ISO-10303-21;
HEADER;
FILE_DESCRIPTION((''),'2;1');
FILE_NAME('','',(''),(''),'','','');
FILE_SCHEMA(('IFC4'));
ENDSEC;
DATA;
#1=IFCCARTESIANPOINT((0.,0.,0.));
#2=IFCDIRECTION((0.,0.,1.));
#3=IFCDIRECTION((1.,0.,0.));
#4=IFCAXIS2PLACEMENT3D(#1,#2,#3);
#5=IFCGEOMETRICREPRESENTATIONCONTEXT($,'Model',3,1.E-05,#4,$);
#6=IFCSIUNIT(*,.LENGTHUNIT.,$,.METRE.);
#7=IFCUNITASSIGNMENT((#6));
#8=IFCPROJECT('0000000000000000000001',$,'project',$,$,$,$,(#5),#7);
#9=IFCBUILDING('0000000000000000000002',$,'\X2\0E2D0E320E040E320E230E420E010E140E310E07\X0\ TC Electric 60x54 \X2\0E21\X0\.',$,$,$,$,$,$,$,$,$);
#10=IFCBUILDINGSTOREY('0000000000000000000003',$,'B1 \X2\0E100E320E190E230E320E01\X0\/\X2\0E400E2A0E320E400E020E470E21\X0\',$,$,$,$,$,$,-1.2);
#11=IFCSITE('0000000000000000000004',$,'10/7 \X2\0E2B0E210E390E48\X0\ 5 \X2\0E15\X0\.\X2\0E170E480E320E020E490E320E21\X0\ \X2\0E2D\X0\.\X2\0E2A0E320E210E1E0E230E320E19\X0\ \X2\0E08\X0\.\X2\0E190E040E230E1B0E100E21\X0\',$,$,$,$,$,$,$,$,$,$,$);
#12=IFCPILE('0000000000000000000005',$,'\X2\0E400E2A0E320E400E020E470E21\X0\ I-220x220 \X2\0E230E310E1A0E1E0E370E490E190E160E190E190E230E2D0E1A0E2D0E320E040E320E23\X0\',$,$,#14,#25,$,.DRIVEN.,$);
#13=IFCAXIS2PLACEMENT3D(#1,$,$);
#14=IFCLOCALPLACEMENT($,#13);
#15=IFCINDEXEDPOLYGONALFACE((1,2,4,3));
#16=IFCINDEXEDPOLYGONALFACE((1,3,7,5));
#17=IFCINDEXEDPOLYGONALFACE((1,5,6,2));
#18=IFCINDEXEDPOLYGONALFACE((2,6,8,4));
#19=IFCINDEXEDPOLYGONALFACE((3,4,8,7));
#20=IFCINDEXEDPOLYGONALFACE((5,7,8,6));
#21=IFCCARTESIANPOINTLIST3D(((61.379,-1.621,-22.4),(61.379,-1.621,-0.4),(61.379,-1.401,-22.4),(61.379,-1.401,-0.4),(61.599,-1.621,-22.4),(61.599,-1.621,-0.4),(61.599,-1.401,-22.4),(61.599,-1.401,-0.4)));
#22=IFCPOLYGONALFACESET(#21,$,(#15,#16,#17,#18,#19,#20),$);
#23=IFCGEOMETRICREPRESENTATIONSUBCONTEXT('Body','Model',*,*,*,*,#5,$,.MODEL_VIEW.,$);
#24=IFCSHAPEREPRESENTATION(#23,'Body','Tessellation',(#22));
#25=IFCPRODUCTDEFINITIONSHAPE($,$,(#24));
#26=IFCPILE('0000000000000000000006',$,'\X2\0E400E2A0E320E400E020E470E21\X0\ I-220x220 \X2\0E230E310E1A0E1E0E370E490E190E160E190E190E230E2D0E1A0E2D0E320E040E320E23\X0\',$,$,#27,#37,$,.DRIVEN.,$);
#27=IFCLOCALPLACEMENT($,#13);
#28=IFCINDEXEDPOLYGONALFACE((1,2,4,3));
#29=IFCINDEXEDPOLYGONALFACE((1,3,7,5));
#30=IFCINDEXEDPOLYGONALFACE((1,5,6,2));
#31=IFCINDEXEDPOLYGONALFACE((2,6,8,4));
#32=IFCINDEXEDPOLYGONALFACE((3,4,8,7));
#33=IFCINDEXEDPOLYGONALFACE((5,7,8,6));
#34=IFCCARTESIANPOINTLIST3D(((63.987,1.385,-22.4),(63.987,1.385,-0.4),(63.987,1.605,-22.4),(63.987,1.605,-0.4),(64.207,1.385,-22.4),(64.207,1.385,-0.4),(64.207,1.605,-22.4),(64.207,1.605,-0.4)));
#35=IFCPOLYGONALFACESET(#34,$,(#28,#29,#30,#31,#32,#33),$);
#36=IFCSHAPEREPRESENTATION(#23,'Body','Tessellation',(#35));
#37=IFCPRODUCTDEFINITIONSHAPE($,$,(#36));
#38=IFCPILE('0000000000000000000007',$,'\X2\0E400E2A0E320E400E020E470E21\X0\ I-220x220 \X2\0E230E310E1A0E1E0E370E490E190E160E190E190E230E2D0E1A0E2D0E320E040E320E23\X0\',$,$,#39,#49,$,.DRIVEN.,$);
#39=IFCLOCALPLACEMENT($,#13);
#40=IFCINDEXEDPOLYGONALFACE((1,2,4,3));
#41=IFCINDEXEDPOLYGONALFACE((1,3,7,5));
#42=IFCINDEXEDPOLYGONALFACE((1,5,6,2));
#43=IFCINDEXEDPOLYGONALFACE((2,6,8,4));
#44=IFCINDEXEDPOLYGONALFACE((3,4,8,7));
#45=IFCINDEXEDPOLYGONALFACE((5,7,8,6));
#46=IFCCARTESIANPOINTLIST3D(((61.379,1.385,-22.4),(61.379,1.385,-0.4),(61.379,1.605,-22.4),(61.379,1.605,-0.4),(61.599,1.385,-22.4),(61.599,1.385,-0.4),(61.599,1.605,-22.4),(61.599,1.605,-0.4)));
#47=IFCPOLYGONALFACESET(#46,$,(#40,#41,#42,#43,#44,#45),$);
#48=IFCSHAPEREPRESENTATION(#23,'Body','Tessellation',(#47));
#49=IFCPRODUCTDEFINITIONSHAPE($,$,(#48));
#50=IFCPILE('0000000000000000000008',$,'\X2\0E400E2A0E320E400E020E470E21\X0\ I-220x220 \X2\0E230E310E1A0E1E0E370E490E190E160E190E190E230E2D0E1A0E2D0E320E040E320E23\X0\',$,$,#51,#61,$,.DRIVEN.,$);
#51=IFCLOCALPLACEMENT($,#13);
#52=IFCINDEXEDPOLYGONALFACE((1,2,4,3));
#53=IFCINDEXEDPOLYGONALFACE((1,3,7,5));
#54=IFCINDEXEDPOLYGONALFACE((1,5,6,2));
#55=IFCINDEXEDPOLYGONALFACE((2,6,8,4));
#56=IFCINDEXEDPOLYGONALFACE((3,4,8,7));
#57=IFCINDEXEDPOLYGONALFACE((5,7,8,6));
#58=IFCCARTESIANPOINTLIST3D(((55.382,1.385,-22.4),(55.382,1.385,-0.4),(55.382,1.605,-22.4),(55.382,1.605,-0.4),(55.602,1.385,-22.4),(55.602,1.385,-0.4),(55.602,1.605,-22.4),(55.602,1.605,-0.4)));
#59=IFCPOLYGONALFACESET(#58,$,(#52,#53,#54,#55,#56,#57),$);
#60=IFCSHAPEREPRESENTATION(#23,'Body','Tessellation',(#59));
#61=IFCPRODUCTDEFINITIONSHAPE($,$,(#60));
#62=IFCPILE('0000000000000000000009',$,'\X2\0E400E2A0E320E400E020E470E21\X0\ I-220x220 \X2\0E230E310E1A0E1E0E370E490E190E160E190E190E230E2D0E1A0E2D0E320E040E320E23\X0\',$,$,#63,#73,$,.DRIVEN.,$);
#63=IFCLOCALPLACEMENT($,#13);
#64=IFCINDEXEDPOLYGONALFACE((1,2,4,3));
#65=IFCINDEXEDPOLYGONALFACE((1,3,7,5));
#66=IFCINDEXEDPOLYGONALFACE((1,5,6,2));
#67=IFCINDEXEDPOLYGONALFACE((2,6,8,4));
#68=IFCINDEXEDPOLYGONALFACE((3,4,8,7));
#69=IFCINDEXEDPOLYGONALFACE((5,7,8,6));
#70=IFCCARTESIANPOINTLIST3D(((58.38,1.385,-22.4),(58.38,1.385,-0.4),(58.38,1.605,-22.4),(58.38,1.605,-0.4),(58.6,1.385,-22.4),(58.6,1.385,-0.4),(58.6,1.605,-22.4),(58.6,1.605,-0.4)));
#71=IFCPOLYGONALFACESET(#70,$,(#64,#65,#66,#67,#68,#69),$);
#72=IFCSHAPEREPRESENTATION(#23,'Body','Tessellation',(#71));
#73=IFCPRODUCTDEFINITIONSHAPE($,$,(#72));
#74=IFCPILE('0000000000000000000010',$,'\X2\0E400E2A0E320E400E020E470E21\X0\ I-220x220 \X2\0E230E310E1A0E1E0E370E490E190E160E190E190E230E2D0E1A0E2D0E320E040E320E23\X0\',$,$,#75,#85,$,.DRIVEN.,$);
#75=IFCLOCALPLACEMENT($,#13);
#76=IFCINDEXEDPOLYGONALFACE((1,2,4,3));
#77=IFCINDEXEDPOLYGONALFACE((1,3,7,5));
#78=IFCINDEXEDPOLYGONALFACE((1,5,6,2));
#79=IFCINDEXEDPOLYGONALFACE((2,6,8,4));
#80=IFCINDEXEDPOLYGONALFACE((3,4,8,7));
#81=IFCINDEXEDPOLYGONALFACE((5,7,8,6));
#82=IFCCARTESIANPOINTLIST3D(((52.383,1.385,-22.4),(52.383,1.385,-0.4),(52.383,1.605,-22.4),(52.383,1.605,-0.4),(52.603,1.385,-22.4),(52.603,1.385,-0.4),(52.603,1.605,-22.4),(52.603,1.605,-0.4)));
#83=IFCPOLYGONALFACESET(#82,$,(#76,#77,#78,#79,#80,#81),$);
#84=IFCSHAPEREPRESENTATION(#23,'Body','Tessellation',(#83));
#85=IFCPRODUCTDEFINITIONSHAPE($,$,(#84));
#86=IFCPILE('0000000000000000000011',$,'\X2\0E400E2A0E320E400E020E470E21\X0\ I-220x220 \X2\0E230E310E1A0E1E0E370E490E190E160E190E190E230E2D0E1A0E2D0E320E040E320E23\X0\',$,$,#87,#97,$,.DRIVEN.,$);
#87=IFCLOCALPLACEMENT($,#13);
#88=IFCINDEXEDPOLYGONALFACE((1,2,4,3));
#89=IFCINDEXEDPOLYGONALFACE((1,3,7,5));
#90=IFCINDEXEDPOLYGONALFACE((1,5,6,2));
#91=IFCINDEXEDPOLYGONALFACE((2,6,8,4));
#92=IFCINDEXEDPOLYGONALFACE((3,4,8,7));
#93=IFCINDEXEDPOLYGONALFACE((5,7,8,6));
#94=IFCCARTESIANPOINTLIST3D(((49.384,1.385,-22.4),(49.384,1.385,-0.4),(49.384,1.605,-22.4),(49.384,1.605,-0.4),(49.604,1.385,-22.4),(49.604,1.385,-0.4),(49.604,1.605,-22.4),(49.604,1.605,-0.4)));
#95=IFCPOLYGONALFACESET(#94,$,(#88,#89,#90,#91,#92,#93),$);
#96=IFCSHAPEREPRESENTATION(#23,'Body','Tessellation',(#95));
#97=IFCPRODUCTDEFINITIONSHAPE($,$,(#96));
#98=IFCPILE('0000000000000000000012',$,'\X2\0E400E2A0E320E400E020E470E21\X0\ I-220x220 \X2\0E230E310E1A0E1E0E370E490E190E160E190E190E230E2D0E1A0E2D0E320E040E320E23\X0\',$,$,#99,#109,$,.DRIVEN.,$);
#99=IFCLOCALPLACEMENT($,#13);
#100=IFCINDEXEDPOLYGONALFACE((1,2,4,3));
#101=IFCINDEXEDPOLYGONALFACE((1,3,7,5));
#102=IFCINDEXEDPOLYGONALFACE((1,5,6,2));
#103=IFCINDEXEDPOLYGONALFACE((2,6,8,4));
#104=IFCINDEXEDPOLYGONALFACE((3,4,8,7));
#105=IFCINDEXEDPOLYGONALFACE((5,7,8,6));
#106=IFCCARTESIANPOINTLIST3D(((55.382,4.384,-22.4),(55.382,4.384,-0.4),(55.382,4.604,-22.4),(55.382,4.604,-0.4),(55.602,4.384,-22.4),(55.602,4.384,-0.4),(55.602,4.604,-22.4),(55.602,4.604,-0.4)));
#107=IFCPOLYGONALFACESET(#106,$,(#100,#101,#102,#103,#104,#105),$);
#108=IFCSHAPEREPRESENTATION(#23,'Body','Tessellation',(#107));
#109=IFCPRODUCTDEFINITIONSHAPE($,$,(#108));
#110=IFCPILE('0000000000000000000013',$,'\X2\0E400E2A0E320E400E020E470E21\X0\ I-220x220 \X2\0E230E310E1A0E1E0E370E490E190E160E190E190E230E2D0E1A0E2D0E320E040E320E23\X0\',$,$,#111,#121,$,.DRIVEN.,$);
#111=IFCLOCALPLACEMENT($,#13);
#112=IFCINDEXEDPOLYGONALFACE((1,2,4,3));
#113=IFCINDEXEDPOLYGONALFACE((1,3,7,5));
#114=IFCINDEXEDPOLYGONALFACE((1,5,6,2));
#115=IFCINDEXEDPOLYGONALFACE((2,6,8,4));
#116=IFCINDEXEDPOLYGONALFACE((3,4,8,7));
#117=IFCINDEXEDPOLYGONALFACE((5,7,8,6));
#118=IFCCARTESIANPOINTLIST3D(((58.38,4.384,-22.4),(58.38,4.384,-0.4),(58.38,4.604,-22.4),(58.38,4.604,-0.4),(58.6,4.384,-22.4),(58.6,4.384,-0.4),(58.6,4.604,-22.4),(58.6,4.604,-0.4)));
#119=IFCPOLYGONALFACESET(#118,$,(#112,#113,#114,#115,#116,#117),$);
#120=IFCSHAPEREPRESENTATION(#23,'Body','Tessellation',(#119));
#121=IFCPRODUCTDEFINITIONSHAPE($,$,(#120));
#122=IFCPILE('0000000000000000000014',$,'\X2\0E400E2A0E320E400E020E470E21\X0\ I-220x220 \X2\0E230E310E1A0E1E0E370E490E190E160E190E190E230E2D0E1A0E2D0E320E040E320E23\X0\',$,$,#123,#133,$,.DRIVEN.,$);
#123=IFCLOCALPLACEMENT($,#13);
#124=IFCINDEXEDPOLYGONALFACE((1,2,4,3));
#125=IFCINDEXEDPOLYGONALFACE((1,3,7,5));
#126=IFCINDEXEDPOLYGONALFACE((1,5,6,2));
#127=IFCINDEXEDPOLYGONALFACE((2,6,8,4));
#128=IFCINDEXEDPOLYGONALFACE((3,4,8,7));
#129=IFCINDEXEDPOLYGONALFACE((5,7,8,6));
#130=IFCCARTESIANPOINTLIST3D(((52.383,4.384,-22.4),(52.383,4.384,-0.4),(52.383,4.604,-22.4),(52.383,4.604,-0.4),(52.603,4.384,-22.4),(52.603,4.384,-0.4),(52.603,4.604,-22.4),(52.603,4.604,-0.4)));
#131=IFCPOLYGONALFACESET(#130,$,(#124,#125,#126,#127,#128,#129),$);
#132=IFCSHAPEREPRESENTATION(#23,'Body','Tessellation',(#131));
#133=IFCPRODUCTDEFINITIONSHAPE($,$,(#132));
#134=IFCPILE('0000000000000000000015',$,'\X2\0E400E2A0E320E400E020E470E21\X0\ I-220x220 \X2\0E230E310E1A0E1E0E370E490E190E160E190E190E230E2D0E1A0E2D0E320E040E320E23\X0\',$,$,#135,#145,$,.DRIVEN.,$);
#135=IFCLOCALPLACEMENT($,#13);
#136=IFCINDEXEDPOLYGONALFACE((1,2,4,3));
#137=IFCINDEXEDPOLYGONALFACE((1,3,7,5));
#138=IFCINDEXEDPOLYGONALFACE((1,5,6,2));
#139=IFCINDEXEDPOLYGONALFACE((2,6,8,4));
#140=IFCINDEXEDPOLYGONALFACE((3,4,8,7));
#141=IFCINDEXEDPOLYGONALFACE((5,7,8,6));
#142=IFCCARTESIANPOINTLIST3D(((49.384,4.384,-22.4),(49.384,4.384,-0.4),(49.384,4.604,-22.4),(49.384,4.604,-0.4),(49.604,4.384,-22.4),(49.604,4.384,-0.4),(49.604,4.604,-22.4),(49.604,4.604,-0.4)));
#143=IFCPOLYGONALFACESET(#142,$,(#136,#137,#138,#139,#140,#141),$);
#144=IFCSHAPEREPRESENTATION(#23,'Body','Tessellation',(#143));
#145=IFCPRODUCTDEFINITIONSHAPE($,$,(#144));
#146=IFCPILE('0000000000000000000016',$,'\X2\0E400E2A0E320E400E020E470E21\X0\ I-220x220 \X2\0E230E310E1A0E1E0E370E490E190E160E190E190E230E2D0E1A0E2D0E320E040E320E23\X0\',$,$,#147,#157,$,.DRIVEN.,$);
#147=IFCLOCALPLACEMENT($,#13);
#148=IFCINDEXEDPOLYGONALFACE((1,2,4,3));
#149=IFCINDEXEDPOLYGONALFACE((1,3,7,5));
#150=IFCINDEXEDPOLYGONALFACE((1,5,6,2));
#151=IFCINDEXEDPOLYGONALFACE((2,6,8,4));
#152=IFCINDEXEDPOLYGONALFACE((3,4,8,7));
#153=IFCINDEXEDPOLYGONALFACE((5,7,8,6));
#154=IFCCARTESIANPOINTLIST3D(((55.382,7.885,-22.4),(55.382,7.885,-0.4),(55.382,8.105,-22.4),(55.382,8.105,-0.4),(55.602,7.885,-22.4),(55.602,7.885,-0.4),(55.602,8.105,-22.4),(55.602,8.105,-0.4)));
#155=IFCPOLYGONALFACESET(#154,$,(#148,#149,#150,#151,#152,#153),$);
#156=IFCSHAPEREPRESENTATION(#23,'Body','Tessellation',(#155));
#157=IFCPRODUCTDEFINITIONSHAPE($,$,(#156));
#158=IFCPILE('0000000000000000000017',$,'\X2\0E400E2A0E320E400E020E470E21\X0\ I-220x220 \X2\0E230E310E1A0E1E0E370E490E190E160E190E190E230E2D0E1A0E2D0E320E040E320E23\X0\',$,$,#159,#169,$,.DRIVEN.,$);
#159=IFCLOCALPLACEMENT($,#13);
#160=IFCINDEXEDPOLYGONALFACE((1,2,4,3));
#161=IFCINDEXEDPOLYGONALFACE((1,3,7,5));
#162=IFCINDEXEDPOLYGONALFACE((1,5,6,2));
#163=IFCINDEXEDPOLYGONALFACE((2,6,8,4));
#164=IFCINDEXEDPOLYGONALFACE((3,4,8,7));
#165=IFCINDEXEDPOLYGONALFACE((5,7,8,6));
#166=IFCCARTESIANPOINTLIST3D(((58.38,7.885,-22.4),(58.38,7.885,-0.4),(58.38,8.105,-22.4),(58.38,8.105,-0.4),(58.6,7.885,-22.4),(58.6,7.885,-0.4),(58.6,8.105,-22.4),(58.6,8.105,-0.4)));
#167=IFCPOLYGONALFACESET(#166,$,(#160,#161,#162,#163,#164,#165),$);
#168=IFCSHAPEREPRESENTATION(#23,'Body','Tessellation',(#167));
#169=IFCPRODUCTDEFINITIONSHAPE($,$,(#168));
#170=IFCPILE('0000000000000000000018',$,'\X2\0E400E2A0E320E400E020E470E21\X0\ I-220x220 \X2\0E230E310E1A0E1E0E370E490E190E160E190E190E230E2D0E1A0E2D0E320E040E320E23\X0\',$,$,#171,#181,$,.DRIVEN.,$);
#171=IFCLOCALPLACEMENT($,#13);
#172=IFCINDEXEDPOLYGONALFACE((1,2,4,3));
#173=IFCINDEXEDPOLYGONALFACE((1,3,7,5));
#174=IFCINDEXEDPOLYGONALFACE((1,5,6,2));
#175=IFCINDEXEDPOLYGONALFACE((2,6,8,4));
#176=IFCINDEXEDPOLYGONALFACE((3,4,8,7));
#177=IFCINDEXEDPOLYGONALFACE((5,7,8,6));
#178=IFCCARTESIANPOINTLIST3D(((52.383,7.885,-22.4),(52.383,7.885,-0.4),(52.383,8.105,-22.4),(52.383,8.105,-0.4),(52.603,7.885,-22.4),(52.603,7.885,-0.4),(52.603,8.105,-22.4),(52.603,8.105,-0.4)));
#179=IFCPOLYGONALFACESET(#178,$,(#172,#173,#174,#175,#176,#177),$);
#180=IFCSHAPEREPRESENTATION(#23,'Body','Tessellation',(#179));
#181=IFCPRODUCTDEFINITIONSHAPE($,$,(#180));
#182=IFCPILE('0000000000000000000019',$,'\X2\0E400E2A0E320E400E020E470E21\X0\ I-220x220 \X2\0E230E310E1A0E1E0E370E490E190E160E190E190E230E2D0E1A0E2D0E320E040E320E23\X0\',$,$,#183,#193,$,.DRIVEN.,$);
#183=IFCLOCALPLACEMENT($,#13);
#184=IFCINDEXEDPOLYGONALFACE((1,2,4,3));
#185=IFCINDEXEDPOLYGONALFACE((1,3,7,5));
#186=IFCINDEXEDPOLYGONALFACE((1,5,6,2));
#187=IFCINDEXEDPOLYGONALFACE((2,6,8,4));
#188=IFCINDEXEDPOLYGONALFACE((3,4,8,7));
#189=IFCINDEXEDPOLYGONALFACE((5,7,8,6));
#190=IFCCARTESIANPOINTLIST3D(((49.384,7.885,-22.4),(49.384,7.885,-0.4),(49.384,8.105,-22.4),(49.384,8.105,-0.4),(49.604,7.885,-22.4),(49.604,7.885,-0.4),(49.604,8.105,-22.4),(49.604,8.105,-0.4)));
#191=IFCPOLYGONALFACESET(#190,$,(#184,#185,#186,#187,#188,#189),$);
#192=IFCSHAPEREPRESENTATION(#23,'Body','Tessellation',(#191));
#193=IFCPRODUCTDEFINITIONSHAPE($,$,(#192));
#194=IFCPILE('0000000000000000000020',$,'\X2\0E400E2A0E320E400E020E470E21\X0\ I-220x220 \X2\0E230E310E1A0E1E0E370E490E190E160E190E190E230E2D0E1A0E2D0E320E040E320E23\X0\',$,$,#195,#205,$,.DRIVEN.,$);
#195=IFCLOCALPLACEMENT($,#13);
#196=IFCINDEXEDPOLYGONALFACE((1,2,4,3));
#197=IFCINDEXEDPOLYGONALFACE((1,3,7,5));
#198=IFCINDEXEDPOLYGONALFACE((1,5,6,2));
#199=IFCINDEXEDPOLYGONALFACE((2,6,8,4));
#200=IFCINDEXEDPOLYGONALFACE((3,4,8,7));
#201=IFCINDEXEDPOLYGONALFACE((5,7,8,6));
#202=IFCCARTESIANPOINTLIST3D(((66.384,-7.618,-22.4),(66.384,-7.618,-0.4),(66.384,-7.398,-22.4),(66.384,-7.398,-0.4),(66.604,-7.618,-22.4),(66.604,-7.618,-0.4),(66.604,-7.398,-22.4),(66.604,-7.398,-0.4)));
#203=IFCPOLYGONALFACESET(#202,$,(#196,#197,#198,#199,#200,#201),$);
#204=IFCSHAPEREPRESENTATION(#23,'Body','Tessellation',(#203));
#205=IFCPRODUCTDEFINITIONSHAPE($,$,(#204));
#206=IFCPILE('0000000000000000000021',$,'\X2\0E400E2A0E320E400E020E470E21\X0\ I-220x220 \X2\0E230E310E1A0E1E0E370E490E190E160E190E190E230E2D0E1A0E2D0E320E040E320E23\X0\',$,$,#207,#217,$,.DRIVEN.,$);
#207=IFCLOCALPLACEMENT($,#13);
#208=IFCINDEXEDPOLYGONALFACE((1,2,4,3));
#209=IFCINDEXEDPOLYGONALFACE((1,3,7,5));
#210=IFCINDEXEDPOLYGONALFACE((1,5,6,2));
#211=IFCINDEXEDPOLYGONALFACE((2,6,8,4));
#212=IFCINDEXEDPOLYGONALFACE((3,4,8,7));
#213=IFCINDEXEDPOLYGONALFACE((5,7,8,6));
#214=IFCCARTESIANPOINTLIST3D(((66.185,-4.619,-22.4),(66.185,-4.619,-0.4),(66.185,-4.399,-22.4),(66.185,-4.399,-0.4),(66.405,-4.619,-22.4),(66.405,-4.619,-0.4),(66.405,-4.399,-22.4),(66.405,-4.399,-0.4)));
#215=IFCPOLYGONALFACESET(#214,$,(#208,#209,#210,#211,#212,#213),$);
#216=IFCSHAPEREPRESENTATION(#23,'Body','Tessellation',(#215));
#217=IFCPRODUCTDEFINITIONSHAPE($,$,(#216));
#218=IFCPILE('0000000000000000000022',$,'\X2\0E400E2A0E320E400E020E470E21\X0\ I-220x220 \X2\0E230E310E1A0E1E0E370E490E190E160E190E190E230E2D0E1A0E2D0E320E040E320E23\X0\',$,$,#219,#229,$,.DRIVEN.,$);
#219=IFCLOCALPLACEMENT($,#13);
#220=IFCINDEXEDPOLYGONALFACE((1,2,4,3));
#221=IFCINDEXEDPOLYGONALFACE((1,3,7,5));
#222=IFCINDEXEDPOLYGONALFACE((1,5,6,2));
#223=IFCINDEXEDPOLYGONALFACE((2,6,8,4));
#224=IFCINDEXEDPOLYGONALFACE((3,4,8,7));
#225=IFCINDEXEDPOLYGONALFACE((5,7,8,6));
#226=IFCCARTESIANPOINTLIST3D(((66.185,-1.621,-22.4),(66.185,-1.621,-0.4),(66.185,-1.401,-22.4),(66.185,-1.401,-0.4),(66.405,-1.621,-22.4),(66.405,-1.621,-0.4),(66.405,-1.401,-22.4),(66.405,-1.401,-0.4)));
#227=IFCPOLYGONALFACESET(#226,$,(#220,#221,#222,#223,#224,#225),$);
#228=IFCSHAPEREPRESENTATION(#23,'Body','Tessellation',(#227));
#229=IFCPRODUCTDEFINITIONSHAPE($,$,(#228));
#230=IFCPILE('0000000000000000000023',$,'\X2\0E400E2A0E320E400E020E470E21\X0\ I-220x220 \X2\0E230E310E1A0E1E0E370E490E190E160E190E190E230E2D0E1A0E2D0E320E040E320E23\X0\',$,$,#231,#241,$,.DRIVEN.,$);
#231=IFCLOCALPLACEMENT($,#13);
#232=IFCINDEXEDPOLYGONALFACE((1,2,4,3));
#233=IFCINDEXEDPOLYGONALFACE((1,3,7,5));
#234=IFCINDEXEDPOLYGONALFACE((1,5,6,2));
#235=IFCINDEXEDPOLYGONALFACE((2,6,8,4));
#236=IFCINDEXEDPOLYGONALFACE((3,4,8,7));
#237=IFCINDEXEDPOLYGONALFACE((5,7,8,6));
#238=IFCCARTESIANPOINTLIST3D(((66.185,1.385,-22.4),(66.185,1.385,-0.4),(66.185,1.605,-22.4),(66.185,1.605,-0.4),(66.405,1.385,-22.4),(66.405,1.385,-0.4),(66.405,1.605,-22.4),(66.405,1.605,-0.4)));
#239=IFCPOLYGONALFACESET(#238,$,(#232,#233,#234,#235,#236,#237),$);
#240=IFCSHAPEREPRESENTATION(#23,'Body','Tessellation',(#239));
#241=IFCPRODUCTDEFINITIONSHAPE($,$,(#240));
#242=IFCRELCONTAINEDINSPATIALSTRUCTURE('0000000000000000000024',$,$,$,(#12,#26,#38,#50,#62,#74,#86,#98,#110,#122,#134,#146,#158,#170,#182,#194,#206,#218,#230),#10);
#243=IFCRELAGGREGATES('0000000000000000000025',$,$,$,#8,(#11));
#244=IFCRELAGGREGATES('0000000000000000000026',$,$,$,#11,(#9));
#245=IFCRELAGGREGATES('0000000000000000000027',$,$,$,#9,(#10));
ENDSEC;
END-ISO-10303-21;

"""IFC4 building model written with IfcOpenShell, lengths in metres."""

from ifc_helpers import new_model, si_unit, frame, origin, origin_with_axes, origin_2d, place, context, subcontext, project, spatial, rectangle, extrude, element, save


model = new_model("IFC4")

# Units and contexts
model_context = context("Model", 3, precision=1e-05, world=origin_with_axes())
body_context = subcontext(model_context, "Body", "Model", "MODEL_VIEW")
ifc_project = project(units=[si_unit("LENGTHUNIT", "METRE")], contexts=[model_context])

# Site, building, storey
site = spatial("IfcSite", under=ifc_project, Name="10/7 หมู่ 5 ต.ท่าข้าม อ.สามพราน จ.นครปฐม")
building = spatial("IfcBuilding", under=site, Name="อาคารโกดัง TC Electric 60x54 ม.")
storey = spatial("IfcBuildingStorey", under=building, Name="B1 ฐานราก/เสาเข็ม", Elevation=-1.2)

# Piles
for number, where, z_axis, x_axis, name in (
    (1, (61.489, -1.511, -22.4), (0.0, 0.0, 1.0), (1.0, 0.0, 0.0), "เสาเข็ม I-220x220 รับพื้นถนนรอบอาคาร"),
    (2, (64.097, 1.495, -22.4), (0.0, 0.0, 1.0), (1.0, 0.0, 0.0), "เสาเข็ม I-220x220 รับพื้นถนนรอบอาคาร"),
    (3, (61.489, 1.495, -22.4), (0.0, 0.0, 1.0), (1.0, 0.0, 0.0), "เสาเข็ม I-220x220 รับพื้นถนนรอบอาคาร"),
    (4, (55.492, 1.495, -22.4), (0.0, 0.0, 1.0), (1.0, 0.0, 0.0), "เสาเข็ม I-220x220 รับพื้นถนนรอบอาคาร"),
    (5, (58.49, 1.495, -22.4), (0.0, 0.0, 1.0), (1.0, 0.0, 0.0), "เสาเข็ม I-220x220 รับพื้นถนนรอบอาคาร"),
    (6, (52.493, 1.495, -22.4), (0.0, 0.0, 1.0), (1.0, 0.0, 0.0), "เสาเข็ม I-220x220 รับพื้นถนนรอบอาคาร"),
    (7, (49.494, 1.495, -22.4), (0.0, 0.0, 1.0), (1.0, 0.0, 0.0), "เสาเข็ม I-220x220 รับพื้นถนนรอบอาคาร"),
    (8, (55.492, 4.494, -22.4), (0.0, 0.0, 1.0), (1.0, 0.0, 0.0), "เสาเข็ม I-220x220 รับพื้นถนนรอบอาคาร"),
    (9, (58.49, 4.494, -22.4), (0.0, 0.0, 1.0), (1.0, 0.0, 0.0), "เสาเข็ม I-220x220 รับพื้นถนนรอบอาคาร"),
    (10, (52.493, 4.494, -22.4), (0.0, 0.0, 1.0), (1.0, 0.0, 0.0), "เสาเข็ม I-220x220 รับพื้นถนนรอบอาคาร"),
    (11, (49.494, 4.494, -22.4), (0.0, 0.0, 1.0), (1.0, 0.0, 0.0), "เสาเข็ม I-220x220 รับพื้นถนนรอบอาคาร"),
    (12, (55.492, 7.995, -22.4), (0.0, 0.0, 1.0), (1.0, 0.0, 0.0), "เสาเข็ม I-220x220 รับพื้นถนนรอบอาคาร"),
    (13, (58.49, 7.995, -22.4), (0.0, 0.0, 1.0), (1.0, 0.0, 0.0), "เสาเข็ม I-220x220 รับพื้นถนนรอบอาคาร"),
    (14, (52.493, 7.995, -22.4), (0.0, 0.0, 1.0), (1.0, 0.0, 0.0), "เสาเข็ม I-220x220 รับพื้นถนนรอบอาคาร"),
    (15, (49.494, 7.995, -22.4), (0.0, 0.0, 1.0), (1.0, 0.0, 0.0), "เสาเข็ม I-220x220 รับพื้นถนนรอบอาคาร"),
    (16, (66.494, -7.508, -22.4), (0.0, 0.0, 1.0), (1.0, 0.0, 0.0), "เสาเข็ม I-220x220 รับพื้นถนนรอบอาคาร"),
    (17, (66.295, -4.509, -22.4), (0.0, 0.0, 1.0), (1.0, 0.0, 0.0), "เสาเข็ม I-220x220 รับพื้นถนนรอบอาคาร"),
    (18, (66.295, -1.511, -22.4), (0.0, 0.0, 1.0), (1.0, 0.0, 0.0), "เสาเข็ม I-220x220 รับพื้นถนนรอบอาคาร"),
    (19, (66.295, 1.495, -22.4), (0.0, 0.0, 1.0), (1.0, 0.0, 0.0), "เสาเข็ม I-220x220 รับพื้นถนนรอบอาคาร"),
):
    element("IfcPile", number, at=place(None, frame(where, z_axis=z_axis, x_axis=x_axis)), inside=storey, Name=name, PredefinedType="DRIVEN", context=body_context, shape_type="SweptSolid", body=[
        extrude(rectangle(XDim=0.22, YDim=0.22, at=origin_2d()), origin(), (0.0, 0.0, 1.0), 22.0),
    ])

save(model, "model.ifc")
